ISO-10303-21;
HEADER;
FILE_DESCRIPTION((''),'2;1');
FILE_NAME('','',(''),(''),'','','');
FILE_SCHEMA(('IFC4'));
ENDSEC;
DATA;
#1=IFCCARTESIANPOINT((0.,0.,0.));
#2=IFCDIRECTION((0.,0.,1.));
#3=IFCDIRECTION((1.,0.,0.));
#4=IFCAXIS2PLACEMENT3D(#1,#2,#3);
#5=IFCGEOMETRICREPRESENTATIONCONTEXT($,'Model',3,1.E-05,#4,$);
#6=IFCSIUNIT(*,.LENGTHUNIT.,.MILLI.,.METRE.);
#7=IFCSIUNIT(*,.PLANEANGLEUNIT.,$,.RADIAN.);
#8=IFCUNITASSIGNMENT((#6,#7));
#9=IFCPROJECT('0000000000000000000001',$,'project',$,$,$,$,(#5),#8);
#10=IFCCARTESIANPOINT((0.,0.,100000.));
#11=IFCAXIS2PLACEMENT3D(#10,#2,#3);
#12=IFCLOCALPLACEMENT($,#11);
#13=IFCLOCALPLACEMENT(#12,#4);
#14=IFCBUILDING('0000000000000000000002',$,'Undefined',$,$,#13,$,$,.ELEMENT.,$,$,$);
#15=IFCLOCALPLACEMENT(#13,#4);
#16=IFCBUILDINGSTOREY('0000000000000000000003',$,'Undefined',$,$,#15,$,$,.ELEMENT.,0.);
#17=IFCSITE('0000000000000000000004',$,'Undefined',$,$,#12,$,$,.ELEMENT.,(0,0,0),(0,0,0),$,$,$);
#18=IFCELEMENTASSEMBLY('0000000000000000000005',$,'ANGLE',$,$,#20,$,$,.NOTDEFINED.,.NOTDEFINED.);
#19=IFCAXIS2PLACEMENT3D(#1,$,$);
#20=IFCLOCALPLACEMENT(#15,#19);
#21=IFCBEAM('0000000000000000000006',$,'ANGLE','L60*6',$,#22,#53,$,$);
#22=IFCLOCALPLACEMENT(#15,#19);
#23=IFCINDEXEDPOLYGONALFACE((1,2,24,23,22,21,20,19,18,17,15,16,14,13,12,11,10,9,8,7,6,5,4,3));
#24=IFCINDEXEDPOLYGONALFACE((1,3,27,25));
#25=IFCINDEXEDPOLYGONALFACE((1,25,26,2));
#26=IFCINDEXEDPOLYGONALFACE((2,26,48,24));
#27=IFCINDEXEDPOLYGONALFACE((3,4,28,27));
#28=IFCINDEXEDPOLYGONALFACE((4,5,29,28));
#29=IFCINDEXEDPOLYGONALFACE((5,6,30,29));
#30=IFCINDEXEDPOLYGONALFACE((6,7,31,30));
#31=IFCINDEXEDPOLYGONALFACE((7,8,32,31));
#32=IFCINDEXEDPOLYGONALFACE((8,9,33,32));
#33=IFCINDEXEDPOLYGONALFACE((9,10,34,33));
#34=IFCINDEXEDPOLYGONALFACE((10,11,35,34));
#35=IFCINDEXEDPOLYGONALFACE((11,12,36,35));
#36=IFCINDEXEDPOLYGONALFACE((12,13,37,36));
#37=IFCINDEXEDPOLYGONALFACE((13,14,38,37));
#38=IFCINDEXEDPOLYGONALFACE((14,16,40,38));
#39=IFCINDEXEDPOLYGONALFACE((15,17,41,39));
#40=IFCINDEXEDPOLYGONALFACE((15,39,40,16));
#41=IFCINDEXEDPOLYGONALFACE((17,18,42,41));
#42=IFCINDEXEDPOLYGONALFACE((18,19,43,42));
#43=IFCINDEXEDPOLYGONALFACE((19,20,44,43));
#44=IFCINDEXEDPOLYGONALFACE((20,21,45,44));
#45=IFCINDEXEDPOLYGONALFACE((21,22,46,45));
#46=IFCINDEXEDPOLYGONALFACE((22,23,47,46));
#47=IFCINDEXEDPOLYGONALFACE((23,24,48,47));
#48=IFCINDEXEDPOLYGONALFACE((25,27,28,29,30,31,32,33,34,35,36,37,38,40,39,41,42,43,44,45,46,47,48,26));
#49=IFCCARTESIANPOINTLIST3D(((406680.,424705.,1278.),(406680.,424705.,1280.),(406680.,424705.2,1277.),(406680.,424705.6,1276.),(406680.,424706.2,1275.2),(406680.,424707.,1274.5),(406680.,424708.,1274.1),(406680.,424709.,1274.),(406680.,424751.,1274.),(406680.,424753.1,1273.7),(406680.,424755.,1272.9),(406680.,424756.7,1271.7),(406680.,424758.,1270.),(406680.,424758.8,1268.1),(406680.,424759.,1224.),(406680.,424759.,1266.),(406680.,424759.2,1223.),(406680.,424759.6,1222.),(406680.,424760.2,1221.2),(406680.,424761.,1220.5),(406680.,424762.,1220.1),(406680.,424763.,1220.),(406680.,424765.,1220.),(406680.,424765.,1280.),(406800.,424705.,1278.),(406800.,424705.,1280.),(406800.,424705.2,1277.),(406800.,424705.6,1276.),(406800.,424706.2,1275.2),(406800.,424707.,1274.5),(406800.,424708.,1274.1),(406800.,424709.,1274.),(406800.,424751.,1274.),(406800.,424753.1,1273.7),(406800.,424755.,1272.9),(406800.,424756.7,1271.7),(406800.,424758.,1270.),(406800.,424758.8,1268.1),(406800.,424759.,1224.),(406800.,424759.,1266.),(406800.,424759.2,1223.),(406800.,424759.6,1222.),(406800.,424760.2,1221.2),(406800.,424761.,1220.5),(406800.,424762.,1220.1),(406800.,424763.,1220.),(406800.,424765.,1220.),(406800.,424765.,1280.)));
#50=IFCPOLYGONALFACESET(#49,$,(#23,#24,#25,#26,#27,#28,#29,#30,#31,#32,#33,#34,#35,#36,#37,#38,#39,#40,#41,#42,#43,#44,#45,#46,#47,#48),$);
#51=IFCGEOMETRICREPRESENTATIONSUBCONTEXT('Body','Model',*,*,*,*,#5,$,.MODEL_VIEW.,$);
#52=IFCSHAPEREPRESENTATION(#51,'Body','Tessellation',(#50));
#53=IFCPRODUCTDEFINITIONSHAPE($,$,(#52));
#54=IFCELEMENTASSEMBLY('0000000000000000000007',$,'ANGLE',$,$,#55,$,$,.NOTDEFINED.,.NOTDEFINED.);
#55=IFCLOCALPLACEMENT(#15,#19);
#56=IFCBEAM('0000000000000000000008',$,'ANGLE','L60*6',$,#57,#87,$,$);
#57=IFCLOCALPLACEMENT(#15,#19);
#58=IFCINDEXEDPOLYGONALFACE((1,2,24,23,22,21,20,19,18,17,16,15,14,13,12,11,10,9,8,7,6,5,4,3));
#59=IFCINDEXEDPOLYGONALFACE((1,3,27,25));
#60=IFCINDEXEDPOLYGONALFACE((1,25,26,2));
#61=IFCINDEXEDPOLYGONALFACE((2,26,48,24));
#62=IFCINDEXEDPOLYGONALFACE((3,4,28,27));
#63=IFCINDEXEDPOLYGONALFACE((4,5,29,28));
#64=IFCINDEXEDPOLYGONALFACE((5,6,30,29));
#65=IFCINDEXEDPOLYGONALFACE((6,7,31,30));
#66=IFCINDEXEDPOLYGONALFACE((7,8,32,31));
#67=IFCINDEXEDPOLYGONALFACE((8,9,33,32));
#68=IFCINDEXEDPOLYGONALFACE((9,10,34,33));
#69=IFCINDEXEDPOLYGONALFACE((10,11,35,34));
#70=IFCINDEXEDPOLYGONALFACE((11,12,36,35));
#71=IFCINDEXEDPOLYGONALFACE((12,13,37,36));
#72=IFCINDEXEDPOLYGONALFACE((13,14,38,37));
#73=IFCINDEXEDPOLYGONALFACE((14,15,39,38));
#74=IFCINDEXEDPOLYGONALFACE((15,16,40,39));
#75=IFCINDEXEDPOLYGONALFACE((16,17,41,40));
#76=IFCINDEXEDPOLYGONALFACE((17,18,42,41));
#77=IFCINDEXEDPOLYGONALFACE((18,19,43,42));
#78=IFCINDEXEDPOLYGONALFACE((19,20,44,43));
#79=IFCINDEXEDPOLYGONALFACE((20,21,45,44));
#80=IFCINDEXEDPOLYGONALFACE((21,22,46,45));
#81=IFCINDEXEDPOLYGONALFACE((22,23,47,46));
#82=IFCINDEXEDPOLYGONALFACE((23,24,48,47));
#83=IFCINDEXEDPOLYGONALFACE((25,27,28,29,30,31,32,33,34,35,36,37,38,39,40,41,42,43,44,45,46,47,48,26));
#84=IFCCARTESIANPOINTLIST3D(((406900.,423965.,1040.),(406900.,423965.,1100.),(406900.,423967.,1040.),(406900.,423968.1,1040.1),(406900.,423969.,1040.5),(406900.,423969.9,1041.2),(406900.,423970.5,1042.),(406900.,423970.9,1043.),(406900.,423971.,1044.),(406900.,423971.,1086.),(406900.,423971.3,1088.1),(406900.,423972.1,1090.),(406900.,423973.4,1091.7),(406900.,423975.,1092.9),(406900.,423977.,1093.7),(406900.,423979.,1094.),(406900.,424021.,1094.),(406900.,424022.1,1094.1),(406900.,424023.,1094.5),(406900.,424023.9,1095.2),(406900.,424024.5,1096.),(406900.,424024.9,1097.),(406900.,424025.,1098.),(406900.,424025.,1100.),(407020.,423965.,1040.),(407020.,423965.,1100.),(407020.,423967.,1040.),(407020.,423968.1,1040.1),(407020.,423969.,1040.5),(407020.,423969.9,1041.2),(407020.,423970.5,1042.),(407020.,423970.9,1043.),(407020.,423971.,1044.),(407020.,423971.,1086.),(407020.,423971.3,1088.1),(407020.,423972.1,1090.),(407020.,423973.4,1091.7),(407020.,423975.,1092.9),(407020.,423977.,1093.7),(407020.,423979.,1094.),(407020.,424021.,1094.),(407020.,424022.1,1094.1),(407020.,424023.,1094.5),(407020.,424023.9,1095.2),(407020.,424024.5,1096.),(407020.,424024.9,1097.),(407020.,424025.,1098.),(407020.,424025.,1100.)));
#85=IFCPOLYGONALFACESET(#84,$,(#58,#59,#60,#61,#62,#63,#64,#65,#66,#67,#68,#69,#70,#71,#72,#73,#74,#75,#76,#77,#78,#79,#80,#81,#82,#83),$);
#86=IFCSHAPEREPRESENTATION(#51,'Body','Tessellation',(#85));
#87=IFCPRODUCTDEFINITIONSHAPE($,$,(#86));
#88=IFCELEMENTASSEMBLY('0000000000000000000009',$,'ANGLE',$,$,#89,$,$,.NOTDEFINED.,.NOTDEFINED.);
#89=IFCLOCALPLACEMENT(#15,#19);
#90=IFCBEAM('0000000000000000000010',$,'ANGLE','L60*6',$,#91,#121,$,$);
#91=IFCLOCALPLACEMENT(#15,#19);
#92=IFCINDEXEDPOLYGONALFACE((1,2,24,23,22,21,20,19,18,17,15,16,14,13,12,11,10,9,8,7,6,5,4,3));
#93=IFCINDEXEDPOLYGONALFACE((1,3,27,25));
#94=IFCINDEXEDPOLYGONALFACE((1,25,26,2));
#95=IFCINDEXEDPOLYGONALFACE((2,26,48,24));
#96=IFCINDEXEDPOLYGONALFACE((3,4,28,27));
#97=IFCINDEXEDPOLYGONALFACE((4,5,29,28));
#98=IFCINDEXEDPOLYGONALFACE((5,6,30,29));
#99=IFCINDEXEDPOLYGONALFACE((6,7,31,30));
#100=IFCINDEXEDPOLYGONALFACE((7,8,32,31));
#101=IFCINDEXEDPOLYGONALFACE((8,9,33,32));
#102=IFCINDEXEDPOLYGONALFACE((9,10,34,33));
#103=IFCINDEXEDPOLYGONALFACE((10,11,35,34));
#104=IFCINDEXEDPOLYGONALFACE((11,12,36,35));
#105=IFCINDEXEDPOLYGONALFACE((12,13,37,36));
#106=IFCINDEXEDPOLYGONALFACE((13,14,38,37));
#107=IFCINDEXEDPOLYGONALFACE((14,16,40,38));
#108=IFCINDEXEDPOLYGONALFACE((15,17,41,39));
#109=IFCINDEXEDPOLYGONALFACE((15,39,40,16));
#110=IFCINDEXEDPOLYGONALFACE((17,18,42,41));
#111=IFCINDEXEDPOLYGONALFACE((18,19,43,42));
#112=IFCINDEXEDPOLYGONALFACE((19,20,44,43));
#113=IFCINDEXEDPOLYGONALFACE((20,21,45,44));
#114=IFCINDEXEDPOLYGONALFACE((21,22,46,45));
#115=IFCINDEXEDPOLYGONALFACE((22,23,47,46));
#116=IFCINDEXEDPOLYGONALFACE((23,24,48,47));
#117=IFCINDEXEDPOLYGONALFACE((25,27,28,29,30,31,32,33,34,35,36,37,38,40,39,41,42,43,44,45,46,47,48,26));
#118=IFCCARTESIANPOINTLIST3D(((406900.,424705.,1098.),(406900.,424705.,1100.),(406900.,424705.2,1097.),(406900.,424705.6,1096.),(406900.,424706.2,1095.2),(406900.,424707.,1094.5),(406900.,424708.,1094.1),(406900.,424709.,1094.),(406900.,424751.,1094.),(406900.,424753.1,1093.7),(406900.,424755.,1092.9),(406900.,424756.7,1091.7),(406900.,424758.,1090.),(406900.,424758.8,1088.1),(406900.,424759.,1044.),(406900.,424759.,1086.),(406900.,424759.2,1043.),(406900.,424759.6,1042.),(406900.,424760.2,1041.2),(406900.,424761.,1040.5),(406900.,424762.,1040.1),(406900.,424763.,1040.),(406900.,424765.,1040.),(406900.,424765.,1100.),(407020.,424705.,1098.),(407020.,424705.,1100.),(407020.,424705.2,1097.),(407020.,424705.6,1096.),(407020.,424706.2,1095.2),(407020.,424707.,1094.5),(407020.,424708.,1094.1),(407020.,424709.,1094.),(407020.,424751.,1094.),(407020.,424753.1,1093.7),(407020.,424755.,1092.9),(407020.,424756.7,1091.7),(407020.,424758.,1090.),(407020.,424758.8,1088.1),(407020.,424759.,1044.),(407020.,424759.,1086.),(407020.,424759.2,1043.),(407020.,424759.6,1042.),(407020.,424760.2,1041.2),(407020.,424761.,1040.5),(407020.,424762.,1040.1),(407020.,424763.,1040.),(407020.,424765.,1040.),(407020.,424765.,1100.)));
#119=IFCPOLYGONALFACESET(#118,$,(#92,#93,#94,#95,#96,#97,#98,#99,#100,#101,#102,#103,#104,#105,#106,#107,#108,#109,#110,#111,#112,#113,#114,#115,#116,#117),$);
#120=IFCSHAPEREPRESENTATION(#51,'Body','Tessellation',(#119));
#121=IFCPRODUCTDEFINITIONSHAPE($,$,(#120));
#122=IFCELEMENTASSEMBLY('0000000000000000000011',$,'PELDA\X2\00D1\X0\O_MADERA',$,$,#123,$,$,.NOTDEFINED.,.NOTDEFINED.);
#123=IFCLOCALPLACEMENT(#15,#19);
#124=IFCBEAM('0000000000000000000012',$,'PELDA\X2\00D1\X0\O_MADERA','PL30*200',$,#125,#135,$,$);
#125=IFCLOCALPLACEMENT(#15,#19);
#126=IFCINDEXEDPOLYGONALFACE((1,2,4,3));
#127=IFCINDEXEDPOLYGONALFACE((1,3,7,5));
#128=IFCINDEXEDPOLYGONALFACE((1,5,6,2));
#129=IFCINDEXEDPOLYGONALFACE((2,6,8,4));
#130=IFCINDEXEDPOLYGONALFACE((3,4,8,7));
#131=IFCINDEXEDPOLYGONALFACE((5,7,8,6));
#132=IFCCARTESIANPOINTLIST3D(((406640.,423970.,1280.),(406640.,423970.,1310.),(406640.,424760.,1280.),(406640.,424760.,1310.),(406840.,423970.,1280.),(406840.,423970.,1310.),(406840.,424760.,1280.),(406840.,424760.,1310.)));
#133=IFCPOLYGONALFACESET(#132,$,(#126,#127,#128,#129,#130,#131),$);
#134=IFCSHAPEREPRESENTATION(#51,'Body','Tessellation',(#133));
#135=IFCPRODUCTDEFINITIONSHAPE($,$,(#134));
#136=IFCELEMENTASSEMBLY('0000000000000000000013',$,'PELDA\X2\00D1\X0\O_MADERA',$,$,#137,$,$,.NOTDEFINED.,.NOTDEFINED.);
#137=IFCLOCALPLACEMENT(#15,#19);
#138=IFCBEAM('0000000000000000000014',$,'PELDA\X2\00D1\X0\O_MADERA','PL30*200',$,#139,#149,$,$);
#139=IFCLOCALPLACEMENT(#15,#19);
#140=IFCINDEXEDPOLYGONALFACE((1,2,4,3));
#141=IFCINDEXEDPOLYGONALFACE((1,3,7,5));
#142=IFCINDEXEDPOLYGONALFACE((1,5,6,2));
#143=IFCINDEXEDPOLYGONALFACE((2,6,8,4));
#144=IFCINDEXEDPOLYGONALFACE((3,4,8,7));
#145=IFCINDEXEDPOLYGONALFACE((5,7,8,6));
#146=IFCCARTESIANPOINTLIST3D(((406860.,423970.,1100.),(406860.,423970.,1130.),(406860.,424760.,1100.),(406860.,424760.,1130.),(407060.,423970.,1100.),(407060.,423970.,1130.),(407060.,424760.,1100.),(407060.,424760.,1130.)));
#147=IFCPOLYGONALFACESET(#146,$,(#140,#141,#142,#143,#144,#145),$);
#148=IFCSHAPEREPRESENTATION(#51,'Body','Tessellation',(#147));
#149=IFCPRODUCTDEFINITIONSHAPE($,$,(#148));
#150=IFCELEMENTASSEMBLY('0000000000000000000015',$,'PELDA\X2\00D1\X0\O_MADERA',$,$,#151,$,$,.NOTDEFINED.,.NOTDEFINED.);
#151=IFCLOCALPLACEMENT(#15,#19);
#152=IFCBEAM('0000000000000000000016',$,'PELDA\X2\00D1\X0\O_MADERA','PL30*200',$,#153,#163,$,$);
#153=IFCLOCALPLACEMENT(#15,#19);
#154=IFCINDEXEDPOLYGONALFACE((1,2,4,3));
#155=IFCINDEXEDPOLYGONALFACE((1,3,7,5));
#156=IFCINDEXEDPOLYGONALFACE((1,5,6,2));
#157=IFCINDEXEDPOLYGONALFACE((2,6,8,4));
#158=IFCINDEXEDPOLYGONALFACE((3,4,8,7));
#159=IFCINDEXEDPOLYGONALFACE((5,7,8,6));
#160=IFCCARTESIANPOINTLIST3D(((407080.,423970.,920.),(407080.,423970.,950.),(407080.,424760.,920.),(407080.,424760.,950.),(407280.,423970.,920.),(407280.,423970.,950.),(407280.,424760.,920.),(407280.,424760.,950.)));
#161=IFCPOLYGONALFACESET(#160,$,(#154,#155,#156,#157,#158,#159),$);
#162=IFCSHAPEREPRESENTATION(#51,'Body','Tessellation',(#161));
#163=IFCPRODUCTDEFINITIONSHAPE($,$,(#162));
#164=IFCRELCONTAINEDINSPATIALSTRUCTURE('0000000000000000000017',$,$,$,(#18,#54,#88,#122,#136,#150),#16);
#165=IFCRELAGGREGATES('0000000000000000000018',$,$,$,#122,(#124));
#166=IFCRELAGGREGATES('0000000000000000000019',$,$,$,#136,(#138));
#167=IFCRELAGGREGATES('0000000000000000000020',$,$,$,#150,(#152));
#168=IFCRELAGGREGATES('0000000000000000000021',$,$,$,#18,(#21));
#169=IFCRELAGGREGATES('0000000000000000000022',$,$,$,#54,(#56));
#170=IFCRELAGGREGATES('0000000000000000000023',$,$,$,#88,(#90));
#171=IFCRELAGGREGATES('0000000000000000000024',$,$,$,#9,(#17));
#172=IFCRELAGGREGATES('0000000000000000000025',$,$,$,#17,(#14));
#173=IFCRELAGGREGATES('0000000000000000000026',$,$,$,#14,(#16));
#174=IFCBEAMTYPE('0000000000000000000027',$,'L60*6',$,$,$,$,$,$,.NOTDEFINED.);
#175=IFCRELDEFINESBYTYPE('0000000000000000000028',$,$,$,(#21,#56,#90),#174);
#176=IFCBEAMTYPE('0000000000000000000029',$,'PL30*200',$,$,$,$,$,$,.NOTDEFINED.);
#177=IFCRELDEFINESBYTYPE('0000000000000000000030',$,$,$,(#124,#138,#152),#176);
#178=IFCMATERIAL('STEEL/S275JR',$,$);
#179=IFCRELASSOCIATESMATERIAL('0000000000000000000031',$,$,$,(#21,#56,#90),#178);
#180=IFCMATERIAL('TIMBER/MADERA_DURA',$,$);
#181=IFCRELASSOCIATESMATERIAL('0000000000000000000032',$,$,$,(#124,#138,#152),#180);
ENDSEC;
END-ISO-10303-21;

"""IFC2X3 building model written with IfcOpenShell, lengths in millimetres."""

from ifc_helpers import new_model, si_unit, frame, origin_with_axes, origin_2d_with_axis, place, context, subcontext, project, spatial, rectangle, l_section, extrude, material, type_object, element, aggregate, save


model = new_model("IFC2X3")

# Units and contexts
model_context = context("Model", 3, precision=1e-05, world=origin_with_axes())
body_context = subcontext(model_context, "Body", "Model", "MODEL_VIEW")
ifc_project = project(units=[si_unit("LENGTHUNIT", "METRE", prefix="MILLI"), si_unit("PLANEANGLEUNIT", "RADIAN")], contexts=[model_context])

# Site, building, storey
site_placement = place(None, frame((0.0, 0.0, 100000.0), z_axis=(0.0, 0.0, 1.0), x_axis=(1.0, 0.0, 0.0)))
site = spatial("IfcSite", under=ifc_project, at=site_placement, Name="Undefined", CompositionType="ELEMENT", RefLatitude=(0, 0, 0), RefLongitude=(0, 0, 0))
building_placement = place(site_placement, origin_with_axes())
building = spatial("IfcBuilding", under=site, at=building_placement, Name="Undefined", CompositionType="ELEMENT")
storey_placement = place(building_placement, origin_with_axes())
storey = spatial("IfcBuildingStorey", under=building, at=storey_placement, Name="Undefined", CompositionType="ELEMENT", Elevation=0.0)

# Shared definitions
ifc_material_1 = material(Name="STEEL/S275JR")

# Element assemblies, beams
beam_type_1 = type_object("IfcBeamType", Name="L60*6", PredefinedType="NOTDEFINED")
assembly_1_placement = place(storey_placement, origin_with_axes())
assembly_1 = element("IfcElementAssembly", 1, at=assembly_1_placement, inside=storey, Name="ANGLE", AssemblyPlace="NOTDEFINED", PredefinedType="NOTDEFINED")
beam_1_placement = place(assembly_1_placement, frame((406680.0, 424735.0, 1250.0), z_axis=(0.0, -1.0, 0.0), x_axis=(1.0, 0.0, 0.0)))
beam_1 = element("IfcBeam", 2, at=beam_1_placement, type_object=beam_type_1, material=ifc_material_1, Name="ANGLE", Description="L60*6", context=body_context, shape_type="SweptSolid", body=[
    extrude(l_section(Depth=60.0, Width=60.0, Thickness=6.0, FilletRadius=8.0, EdgeRadius=4.0, at=origin_2d_with_axis()), frame((120.0, 0.0, 0.0), z_axis=(-1.0, 0.0, 0.0), x_axis=(0.0, -1.0, 0.0)), (0.0, 0.0, 1.0), 120.0),
])
assembly_2_placement = place(storey_placement, origin_with_axes())
assembly_2 = element("IfcElementAssembly", 3, at=assembly_2_placement, inside=storey, Name="ANGLE", AssemblyPlace="NOTDEFINED", PredefinedType="NOTDEFINED")
beam_2_placement = place(assembly_2_placement, frame((407020.0, 423995.0, 1070.0), z_axis=(0.0, 1.0, 0.0), x_axis=(-1.0, 0.0, 0.0)))
beam_2 = element("IfcBeam", 4, at=beam_2_placement, type_object=beam_type_1, material=ifc_material_1, Name="ANGLE", Description="L60*6", context=body_context, shape_type="SweptSolid", body=[
    extrude(l_section(Depth=60.0, Width=60.0, Thickness=6.0, FilletRadius=8.0, EdgeRadius=4.0, at=origin_2d_with_axis()), frame((120.0, 0.0, 0.0), z_axis=(-1.0, 0.0, 0.0), x_axis=(0.0, -1.0, 0.0)), (0.0, 0.0, 1.0), 120.0),
])
assembly_3_placement = place(storey_placement, origin_with_axes())
assembly_3 = element("IfcElementAssembly", 5, at=assembly_3_placement, inside=storey, Name="ANGLE", AssemblyPlace="NOTDEFINED", PredefinedType="NOTDEFINED")
beam_3_placement = place(assembly_3_placement, frame((406900.0, 424735.0, 1070.0), z_axis=(0.0, -1.0, 0.0), x_axis=(1.0, 0.0, 0.0)))
beam_3 = element("IfcBeam", 6, at=beam_3_placement, type_object=beam_type_1, material=ifc_material_1, Name="ANGLE", Description="L60*6", context=body_context, shape_type="SweptSolid", body=[
    extrude(l_section(Depth=60.0, Width=60.0, Thickness=6.0, FilletRadius=8.0, EdgeRadius=4.0, at=origin_2d_with_axis()), frame((120.0, 0.0, 0.0), z_axis=(-1.0, 0.0, 0.0), x_axis=(0.0, -1.0, 0.0)), (0.0, 0.0, 1.0), 120.0),
])
assembly_4_placement = place(storey_placement, origin_with_axes())
assembly_4 = element("IfcElementAssembly", 7, at=assembly_4_placement, inside=storey, Name="PELDAÑO_MADERA", AssemblyPlace="NOTDEFINED", PredefinedType="NOTDEFINED")
ifc_material_2 = material(Name="TIMBER/MADERA_DURA")
beam_type_2 = type_object("IfcBeamType", Name="PL30*200", PredefinedType="NOTDEFINED")
beam_4_placement = place(assembly_4_placement, frame((406740.0, 424760.0, 1295.0), z_axis=(-1.0, 0.0, 0.0), x_axis=(0.0, -1.0, 0.0)))
beam_4 = element("IfcBeam", 8, at=beam_4_placement, type_object=beam_type_2, material=ifc_material_2, Name="PELDAÑO_MADERA", Description="PL30*200", context=body_context, shape_type="SweptSolid", body=[
    extrude(rectangle(XDim=30.0, YDim=200.0, at=origin_2d_with_axis()), frame((790.0, 0.0, 0.0), z_axis=(-1.0, 0.0, 0.0), x_axis=(0.0, -1.0, 0.0)), (0.0, 0.0, 1.0), 790.0),
])
aggregate(assembly_4, [beam_4])
assembly_5_placement = place(storey_placement, origin_with_axes())
assembly_5 = element("IfcElementAssembly", 9, at=assembly_5_placement, inside=storey, Name="PELDAÑO_MADERA", AssemblyPlace="NOTDEFINED", PredefinedType="NOTDEFINED")
beam_5_placement = place(assembly_5_placement, frame((406960.0, 424760.0, 1115.0), z_axis=(-1.0, 0.0, 0.0), x_axis=(0.0, -1.0, 0.0)))
beam_5 = element("IfcBeam", 10, at=beam_5_placement, type_object=beam_type_2, material=ifc_material_2, Name="PELDAÑO_MADERA", Description="PL30*200", context=body_context, shape_type="SweptSolid", body=[
    extrude(rectangle(XDim=30.0, YDim=200.0, at=origin_2d_with_axis()), frame((790.0, 0.0, 0.0), z_axis=(-1.0, 0.0, 0.0), x_axis=(0.0, -1.0, 0.0)), (0.0, 0.0, 1.0), 790.0),
])
aggregate(assembly_5, [beam_5])
assembly_6_placement = place(storey_placement, origin_with_axes())
assembly_6 = element("IfcElementAssembly", 11, at=assembly_6_placement, inside=storey, Name="PELDAÑO_MADERA", AssemblyPlace="NOTDEFINED", PredefinedType="NOTDEFINED")
beam_6_placement = place(assembly_6_placement, frame((407180.0, 424760.0, 935.0), z_axis=(-1.0, 0.0, 0.0), x_axis=(0.0, -1.0, 0.0)))
beam_6 = element("IfcBeam", 12, at=beam_6_placement, type_object=beam_type_2, material=ifc_material_2, Name="PELDAÑO_MADERA", Description="PL30*200", context=body_context, shape_type="SweptSolid", body=[
    extrude(rectangle(XDim=30.0, YDim=200.0, at=origin_2d_with_axis()), frame((790.0, 0.0, 0.0), z_axis=(-1.0, 0.0, 0.0), x_axis=(0.0, -1.0, 0.0)), (0.0, 0.0, 1.0), 790.0),
])
aggregate(assembly_6, [beam_6])

aggregate(assembly_1, [beam_1])
aggregate(assembly_2, [beam_2])
aggregate(assembly_3, [beam_3])

save(model, "model.ifc")
